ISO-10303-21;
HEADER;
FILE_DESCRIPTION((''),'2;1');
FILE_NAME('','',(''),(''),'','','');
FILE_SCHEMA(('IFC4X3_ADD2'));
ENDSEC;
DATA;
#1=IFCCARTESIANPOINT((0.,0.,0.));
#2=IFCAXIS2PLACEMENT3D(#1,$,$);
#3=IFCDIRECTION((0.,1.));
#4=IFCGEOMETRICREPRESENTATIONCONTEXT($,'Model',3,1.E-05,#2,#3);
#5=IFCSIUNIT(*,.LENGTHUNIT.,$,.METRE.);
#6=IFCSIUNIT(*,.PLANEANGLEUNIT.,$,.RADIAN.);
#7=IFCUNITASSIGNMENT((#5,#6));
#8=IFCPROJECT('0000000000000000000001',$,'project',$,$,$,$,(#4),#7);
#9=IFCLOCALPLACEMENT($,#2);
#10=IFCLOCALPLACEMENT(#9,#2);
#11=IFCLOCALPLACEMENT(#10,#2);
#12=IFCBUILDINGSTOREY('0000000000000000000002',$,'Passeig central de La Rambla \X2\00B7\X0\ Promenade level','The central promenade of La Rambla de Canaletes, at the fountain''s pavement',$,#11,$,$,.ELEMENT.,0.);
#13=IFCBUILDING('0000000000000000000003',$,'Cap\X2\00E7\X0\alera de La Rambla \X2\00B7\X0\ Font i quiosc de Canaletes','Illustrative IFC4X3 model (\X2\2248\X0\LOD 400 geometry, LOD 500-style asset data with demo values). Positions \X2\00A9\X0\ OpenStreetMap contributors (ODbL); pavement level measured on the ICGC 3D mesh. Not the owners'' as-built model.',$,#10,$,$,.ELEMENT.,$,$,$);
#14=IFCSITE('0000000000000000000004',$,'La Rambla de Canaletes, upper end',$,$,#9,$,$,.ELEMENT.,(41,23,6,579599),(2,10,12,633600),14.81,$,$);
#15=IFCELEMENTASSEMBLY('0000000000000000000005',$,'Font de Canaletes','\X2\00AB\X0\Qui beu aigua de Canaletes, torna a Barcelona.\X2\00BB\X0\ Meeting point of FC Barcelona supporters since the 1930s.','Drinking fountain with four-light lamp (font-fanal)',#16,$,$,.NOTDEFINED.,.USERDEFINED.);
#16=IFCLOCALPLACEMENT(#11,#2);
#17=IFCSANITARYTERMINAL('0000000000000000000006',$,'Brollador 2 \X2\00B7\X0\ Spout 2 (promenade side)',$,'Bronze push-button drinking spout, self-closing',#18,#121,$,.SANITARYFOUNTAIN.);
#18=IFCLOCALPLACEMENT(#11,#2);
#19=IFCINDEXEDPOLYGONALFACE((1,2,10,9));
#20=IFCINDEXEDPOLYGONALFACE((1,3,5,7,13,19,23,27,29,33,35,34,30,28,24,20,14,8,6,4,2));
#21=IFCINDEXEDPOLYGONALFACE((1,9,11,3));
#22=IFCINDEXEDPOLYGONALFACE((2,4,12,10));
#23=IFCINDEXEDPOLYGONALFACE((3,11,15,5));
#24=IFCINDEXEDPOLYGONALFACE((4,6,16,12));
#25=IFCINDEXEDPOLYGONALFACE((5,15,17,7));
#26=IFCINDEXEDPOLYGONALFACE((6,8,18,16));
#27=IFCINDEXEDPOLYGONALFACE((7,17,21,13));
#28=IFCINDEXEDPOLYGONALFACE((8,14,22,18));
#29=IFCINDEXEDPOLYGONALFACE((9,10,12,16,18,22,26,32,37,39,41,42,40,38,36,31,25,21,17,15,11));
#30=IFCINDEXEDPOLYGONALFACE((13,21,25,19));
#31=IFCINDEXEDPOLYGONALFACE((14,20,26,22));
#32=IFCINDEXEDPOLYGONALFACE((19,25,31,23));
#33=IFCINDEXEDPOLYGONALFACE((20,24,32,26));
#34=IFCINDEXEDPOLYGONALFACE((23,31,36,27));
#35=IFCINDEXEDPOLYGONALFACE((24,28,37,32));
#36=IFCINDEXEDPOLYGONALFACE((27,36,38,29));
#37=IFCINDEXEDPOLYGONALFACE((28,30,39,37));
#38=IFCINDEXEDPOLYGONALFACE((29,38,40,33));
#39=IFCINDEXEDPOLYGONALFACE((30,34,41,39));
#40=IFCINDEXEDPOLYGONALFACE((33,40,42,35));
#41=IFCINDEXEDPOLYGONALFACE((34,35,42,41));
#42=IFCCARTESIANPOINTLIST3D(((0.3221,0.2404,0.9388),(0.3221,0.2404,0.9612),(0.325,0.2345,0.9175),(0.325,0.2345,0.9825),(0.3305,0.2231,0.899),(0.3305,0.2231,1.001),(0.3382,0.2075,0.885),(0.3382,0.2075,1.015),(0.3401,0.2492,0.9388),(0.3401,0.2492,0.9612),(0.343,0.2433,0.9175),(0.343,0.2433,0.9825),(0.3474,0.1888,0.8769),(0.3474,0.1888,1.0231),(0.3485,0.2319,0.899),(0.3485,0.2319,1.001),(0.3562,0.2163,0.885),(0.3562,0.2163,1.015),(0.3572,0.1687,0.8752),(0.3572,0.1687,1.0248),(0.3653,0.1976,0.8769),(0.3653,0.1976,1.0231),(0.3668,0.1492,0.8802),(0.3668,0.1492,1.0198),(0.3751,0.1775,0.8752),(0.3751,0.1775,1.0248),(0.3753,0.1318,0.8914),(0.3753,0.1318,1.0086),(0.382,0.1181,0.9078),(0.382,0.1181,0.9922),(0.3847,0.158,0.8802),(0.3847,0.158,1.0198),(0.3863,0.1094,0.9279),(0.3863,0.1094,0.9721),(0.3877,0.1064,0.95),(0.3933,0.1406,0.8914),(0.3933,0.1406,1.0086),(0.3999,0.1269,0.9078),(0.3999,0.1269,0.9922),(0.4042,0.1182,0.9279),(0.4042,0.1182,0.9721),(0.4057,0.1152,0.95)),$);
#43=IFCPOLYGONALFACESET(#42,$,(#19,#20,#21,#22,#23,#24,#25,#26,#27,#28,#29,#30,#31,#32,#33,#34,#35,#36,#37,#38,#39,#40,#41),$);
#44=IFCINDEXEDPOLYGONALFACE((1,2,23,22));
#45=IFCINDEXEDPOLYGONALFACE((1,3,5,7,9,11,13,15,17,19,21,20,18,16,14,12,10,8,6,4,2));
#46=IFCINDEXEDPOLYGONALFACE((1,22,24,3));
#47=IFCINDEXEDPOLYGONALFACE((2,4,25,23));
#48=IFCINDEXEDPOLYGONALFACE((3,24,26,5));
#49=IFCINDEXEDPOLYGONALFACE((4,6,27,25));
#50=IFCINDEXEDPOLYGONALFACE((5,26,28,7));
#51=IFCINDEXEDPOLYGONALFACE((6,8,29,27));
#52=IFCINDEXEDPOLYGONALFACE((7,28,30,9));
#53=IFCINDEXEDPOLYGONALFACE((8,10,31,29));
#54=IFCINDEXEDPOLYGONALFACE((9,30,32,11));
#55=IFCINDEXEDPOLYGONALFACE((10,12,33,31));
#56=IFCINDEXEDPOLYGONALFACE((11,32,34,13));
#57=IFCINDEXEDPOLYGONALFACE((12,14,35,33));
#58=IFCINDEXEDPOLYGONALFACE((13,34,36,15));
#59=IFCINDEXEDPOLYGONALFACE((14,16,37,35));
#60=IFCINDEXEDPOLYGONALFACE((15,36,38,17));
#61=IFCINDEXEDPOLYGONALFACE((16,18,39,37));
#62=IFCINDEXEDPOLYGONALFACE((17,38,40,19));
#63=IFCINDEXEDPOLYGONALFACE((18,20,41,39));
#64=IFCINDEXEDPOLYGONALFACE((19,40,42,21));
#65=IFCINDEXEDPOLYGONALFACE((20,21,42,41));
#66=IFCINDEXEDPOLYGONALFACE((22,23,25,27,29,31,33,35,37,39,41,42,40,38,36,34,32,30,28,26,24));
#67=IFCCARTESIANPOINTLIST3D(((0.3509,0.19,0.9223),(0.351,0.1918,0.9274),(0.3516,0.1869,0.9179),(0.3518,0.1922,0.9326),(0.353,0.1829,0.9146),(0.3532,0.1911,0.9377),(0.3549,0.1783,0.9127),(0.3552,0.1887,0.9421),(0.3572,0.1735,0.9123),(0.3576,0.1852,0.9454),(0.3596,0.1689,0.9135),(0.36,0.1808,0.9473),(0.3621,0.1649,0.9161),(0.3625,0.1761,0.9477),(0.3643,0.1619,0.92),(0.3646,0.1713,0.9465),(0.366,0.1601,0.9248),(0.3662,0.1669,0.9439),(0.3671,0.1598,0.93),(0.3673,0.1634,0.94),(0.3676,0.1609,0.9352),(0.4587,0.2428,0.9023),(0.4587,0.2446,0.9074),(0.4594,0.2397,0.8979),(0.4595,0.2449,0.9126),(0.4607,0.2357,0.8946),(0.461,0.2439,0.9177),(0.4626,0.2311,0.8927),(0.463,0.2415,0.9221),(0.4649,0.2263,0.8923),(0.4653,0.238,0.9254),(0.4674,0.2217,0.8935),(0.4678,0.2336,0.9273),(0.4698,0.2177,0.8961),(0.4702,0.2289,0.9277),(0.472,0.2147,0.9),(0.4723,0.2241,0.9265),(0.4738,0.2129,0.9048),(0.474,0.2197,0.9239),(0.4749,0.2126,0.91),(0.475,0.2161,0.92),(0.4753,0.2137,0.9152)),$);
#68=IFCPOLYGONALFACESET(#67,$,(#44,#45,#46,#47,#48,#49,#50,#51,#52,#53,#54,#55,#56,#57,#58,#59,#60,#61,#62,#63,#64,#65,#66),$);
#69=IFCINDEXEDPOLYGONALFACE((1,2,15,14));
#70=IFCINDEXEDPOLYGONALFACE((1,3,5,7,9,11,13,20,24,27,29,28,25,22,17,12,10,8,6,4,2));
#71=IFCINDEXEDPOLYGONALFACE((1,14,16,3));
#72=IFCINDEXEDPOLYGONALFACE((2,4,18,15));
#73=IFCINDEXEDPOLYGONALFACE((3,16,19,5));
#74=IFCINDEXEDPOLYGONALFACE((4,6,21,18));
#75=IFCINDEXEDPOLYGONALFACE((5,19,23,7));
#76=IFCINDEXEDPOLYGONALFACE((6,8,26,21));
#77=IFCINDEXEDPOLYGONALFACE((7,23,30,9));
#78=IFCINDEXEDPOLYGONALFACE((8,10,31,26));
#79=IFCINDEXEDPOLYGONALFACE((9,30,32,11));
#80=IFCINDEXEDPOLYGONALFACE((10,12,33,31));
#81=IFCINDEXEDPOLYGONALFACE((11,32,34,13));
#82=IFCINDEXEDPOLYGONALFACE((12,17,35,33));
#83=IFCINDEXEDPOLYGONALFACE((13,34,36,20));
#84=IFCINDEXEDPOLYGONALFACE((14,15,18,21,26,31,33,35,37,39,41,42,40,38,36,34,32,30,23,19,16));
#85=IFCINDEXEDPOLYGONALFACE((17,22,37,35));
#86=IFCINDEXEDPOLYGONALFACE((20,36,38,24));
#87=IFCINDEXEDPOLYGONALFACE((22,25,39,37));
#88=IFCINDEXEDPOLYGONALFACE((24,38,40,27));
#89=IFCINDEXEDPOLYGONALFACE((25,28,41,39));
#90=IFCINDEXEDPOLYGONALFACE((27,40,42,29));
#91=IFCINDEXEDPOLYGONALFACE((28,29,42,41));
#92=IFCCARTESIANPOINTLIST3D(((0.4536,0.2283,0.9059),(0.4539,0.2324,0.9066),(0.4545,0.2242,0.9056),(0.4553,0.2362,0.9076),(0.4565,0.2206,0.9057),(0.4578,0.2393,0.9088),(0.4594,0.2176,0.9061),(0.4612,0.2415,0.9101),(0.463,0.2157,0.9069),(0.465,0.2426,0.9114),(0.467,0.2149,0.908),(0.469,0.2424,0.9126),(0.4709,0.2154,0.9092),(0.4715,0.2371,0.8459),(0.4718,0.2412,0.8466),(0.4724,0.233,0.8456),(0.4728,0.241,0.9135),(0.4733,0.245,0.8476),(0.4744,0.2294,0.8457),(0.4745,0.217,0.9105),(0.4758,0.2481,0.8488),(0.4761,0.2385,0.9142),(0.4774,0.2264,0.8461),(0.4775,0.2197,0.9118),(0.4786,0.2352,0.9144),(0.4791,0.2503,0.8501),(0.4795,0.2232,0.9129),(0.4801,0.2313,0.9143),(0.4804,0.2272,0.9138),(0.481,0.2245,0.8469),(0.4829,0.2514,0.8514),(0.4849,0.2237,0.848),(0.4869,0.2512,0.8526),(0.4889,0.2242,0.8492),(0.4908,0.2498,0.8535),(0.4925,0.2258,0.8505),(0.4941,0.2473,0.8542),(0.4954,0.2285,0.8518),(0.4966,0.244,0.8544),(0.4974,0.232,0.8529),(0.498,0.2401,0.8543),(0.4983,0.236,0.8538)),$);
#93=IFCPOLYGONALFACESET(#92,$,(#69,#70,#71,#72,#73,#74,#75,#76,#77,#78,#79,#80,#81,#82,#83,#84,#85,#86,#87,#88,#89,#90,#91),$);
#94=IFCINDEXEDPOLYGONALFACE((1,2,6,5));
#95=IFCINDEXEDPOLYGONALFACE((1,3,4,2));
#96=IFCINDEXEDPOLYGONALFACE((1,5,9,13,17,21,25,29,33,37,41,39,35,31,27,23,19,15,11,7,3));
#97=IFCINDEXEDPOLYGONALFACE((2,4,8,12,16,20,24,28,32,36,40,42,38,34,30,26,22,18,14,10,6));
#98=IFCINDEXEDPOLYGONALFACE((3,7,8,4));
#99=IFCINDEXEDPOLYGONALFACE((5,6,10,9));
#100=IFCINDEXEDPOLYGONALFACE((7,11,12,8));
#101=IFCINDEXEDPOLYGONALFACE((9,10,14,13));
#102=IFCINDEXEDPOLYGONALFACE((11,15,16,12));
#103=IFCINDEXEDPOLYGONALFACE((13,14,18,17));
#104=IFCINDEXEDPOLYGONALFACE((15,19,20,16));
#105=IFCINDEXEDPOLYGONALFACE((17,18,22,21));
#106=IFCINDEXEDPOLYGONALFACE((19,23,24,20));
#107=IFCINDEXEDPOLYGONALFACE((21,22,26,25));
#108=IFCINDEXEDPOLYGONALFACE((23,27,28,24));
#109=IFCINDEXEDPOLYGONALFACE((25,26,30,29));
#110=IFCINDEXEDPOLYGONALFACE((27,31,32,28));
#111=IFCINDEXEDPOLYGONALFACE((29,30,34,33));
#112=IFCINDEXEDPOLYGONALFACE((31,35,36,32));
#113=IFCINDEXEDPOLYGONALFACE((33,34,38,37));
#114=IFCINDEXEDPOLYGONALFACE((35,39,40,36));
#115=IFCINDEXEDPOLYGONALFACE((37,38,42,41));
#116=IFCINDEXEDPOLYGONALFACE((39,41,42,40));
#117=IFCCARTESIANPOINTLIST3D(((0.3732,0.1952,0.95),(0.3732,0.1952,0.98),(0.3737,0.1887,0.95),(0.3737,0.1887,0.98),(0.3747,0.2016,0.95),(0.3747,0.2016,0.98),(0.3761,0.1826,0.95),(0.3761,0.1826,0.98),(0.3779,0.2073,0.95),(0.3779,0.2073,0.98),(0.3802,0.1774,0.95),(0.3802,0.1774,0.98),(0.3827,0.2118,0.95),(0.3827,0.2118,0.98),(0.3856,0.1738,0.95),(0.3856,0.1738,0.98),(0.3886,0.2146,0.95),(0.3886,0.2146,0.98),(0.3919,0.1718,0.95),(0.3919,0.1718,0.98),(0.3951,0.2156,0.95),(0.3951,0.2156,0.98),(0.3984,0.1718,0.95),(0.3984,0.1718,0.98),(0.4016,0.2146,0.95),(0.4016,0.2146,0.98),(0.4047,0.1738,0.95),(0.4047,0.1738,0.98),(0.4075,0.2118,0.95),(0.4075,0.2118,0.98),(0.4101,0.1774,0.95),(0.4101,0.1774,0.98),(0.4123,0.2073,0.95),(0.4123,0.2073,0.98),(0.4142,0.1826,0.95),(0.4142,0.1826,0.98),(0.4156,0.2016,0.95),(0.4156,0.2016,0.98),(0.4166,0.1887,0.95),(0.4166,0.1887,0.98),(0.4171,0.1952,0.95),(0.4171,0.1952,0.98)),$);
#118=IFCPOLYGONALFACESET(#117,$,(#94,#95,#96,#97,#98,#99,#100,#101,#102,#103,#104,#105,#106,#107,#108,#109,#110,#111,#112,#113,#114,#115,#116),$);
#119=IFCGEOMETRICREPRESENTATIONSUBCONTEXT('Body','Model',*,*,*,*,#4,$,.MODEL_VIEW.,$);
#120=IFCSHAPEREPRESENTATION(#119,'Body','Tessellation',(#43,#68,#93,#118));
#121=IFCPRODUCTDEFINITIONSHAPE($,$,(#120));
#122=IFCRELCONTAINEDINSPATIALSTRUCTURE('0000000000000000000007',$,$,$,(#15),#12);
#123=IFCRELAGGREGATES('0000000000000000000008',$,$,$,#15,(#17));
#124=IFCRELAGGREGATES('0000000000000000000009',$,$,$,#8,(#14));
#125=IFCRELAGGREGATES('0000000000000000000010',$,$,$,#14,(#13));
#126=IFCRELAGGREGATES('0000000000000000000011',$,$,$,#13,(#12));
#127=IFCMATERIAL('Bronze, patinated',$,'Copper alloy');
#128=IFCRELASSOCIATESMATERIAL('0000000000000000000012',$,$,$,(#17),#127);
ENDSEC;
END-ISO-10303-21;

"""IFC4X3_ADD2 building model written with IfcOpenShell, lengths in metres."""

from ifc_helpers import new_model, si_unit, direction, frame, origin, origin_2d_with_axis, place, context, subcontext, project, spatial, circle, extrude, material, element, aggregate, save


model = new_model("IFC4X3_ADD2")

# Units and contexts
model_context = context("Model", 3, precision=1e-05, world=origin(), true_north=direction((0.0, 1.0)))
body_context = subcontext(model_context, "Body", "Model", "MODEL_VIEW")
ifc_project = project(units=[si_unit("LENGTHUNIT", "METRE"), si_unit("PLANEANGLEUNIT", "RADIAN")], contexts=[model_context])

# Site, building, storey
site_placement = place(None, origin())
site = spatial("IfcSite", under=ifc_project, at=site_placement, Name="La Rambla de Canaletes, upper end", CompositionType="ELEMENT", RefLatitude=(41, 23, 6, 579599), RefLongitude=(2, 10, 12, 633600), RefElevation=14.81)
building_placement = place(site_placement, origin())
building = spatial("IfcBuilding", under=site, at=building_placement, Name="Capçalera de La Rambla · Font i quiosc de Canaletes", Description="Illustrative IFC4X3 model (≈LOD 400 geometry, LOD 500-style asset data with demo values). Positions © OpenStreetMap contributors (ODbL); pavement level measured on the ICGC 3D mesh. Not the owners' as-built model.", CompositionType="ELEMENT")
storey_placement = place(building_placement, origin())
storey = spatial("IfcBuildingStorey", under=building, at=storey_placement, Name="Passeig central de La Rambla · Promenade level", Description="The central promenade of La Rambla de Canaletes, at the fountain's pavement", CompositionType="ELEMENT", Elevation=0.0)

# Element assembly, sanitary terminal
assembly_1_placement = place(building_placement, origin())
assembly_1 = element("IfcElementAssembly", 1, at=assembly_1_placement, inside=storey, Name="Font de Canaletes", Description="«Qui beu aigua de Canaletes, torna a Barcelona.» Meeting point of FC Barcelona supporters since the 1930s.", ObjectType="Drinking fountain with four-light lamp (font-fanal)", AssemblyPlace="NOTDEFINED", PredefinedType="USERDEFINED")
ifc_material_1 = material(Name="Bronze, patinated", Category="Copper alloy")
sanitary_terminal_1_placement = place(building_placement, origin())
sanitary_terminal_1 = element("IfcSanitaryTerminal", 2, at=sanitary_terminal_1_placement, material=ifc_material_1, Name="Brollador 2 · Spout 2 (promenade side)", ObjectType="Bronze push-button drinking spout, self-closing", PredefinedType="SANITARYFOUNTAIN", context=body_context, shape_type="SweptSolid", body=[
    extrude(circle(Radius=0.075, at=origin_2d_with_axis()), frame((0.3547, 0.1738, 0.95), z_axis=(0.898028, 0.439939, 0.0), x_axis=(0.439939, -0.898028, 0.0)), (0.0, 0.0, 1.0), 0.02),
    extrude(circle(Radius=0.018, at=origin_2d_with_axis()), frame((0.3592, 0.176, 0.93), z_axis=(0.885809, 0.433953, -0.164399), x_axis=(0.439939, -0.898028, 0.0)), (0.0, 0.0, 1.0), 0.1217),
    extrude(circle(Radius=0.014, at=origin_2d_with_axis()), frame((0.467, 0.2288, 0.91), z_axis=(0.283981, 0.139121, -0.948683), x_axis=(0.0, -0.989418, -0.145095)), (0.0, 0.0, 1.0), 0.0632),
    extrude(circle(Radius=0.022, at=origin_2d_with_axis()), frame((0.3951, 0.1936, 0.95), z_axis=(0.0, 0.0, 1.0), x_axis=(0.0, 1.0, 0.0)), (0.0, 0.0, 1.0), 0.03),
])
aggregate(assembly_1, [sanitary_terminal_1])

save(model, "model.ifc")
